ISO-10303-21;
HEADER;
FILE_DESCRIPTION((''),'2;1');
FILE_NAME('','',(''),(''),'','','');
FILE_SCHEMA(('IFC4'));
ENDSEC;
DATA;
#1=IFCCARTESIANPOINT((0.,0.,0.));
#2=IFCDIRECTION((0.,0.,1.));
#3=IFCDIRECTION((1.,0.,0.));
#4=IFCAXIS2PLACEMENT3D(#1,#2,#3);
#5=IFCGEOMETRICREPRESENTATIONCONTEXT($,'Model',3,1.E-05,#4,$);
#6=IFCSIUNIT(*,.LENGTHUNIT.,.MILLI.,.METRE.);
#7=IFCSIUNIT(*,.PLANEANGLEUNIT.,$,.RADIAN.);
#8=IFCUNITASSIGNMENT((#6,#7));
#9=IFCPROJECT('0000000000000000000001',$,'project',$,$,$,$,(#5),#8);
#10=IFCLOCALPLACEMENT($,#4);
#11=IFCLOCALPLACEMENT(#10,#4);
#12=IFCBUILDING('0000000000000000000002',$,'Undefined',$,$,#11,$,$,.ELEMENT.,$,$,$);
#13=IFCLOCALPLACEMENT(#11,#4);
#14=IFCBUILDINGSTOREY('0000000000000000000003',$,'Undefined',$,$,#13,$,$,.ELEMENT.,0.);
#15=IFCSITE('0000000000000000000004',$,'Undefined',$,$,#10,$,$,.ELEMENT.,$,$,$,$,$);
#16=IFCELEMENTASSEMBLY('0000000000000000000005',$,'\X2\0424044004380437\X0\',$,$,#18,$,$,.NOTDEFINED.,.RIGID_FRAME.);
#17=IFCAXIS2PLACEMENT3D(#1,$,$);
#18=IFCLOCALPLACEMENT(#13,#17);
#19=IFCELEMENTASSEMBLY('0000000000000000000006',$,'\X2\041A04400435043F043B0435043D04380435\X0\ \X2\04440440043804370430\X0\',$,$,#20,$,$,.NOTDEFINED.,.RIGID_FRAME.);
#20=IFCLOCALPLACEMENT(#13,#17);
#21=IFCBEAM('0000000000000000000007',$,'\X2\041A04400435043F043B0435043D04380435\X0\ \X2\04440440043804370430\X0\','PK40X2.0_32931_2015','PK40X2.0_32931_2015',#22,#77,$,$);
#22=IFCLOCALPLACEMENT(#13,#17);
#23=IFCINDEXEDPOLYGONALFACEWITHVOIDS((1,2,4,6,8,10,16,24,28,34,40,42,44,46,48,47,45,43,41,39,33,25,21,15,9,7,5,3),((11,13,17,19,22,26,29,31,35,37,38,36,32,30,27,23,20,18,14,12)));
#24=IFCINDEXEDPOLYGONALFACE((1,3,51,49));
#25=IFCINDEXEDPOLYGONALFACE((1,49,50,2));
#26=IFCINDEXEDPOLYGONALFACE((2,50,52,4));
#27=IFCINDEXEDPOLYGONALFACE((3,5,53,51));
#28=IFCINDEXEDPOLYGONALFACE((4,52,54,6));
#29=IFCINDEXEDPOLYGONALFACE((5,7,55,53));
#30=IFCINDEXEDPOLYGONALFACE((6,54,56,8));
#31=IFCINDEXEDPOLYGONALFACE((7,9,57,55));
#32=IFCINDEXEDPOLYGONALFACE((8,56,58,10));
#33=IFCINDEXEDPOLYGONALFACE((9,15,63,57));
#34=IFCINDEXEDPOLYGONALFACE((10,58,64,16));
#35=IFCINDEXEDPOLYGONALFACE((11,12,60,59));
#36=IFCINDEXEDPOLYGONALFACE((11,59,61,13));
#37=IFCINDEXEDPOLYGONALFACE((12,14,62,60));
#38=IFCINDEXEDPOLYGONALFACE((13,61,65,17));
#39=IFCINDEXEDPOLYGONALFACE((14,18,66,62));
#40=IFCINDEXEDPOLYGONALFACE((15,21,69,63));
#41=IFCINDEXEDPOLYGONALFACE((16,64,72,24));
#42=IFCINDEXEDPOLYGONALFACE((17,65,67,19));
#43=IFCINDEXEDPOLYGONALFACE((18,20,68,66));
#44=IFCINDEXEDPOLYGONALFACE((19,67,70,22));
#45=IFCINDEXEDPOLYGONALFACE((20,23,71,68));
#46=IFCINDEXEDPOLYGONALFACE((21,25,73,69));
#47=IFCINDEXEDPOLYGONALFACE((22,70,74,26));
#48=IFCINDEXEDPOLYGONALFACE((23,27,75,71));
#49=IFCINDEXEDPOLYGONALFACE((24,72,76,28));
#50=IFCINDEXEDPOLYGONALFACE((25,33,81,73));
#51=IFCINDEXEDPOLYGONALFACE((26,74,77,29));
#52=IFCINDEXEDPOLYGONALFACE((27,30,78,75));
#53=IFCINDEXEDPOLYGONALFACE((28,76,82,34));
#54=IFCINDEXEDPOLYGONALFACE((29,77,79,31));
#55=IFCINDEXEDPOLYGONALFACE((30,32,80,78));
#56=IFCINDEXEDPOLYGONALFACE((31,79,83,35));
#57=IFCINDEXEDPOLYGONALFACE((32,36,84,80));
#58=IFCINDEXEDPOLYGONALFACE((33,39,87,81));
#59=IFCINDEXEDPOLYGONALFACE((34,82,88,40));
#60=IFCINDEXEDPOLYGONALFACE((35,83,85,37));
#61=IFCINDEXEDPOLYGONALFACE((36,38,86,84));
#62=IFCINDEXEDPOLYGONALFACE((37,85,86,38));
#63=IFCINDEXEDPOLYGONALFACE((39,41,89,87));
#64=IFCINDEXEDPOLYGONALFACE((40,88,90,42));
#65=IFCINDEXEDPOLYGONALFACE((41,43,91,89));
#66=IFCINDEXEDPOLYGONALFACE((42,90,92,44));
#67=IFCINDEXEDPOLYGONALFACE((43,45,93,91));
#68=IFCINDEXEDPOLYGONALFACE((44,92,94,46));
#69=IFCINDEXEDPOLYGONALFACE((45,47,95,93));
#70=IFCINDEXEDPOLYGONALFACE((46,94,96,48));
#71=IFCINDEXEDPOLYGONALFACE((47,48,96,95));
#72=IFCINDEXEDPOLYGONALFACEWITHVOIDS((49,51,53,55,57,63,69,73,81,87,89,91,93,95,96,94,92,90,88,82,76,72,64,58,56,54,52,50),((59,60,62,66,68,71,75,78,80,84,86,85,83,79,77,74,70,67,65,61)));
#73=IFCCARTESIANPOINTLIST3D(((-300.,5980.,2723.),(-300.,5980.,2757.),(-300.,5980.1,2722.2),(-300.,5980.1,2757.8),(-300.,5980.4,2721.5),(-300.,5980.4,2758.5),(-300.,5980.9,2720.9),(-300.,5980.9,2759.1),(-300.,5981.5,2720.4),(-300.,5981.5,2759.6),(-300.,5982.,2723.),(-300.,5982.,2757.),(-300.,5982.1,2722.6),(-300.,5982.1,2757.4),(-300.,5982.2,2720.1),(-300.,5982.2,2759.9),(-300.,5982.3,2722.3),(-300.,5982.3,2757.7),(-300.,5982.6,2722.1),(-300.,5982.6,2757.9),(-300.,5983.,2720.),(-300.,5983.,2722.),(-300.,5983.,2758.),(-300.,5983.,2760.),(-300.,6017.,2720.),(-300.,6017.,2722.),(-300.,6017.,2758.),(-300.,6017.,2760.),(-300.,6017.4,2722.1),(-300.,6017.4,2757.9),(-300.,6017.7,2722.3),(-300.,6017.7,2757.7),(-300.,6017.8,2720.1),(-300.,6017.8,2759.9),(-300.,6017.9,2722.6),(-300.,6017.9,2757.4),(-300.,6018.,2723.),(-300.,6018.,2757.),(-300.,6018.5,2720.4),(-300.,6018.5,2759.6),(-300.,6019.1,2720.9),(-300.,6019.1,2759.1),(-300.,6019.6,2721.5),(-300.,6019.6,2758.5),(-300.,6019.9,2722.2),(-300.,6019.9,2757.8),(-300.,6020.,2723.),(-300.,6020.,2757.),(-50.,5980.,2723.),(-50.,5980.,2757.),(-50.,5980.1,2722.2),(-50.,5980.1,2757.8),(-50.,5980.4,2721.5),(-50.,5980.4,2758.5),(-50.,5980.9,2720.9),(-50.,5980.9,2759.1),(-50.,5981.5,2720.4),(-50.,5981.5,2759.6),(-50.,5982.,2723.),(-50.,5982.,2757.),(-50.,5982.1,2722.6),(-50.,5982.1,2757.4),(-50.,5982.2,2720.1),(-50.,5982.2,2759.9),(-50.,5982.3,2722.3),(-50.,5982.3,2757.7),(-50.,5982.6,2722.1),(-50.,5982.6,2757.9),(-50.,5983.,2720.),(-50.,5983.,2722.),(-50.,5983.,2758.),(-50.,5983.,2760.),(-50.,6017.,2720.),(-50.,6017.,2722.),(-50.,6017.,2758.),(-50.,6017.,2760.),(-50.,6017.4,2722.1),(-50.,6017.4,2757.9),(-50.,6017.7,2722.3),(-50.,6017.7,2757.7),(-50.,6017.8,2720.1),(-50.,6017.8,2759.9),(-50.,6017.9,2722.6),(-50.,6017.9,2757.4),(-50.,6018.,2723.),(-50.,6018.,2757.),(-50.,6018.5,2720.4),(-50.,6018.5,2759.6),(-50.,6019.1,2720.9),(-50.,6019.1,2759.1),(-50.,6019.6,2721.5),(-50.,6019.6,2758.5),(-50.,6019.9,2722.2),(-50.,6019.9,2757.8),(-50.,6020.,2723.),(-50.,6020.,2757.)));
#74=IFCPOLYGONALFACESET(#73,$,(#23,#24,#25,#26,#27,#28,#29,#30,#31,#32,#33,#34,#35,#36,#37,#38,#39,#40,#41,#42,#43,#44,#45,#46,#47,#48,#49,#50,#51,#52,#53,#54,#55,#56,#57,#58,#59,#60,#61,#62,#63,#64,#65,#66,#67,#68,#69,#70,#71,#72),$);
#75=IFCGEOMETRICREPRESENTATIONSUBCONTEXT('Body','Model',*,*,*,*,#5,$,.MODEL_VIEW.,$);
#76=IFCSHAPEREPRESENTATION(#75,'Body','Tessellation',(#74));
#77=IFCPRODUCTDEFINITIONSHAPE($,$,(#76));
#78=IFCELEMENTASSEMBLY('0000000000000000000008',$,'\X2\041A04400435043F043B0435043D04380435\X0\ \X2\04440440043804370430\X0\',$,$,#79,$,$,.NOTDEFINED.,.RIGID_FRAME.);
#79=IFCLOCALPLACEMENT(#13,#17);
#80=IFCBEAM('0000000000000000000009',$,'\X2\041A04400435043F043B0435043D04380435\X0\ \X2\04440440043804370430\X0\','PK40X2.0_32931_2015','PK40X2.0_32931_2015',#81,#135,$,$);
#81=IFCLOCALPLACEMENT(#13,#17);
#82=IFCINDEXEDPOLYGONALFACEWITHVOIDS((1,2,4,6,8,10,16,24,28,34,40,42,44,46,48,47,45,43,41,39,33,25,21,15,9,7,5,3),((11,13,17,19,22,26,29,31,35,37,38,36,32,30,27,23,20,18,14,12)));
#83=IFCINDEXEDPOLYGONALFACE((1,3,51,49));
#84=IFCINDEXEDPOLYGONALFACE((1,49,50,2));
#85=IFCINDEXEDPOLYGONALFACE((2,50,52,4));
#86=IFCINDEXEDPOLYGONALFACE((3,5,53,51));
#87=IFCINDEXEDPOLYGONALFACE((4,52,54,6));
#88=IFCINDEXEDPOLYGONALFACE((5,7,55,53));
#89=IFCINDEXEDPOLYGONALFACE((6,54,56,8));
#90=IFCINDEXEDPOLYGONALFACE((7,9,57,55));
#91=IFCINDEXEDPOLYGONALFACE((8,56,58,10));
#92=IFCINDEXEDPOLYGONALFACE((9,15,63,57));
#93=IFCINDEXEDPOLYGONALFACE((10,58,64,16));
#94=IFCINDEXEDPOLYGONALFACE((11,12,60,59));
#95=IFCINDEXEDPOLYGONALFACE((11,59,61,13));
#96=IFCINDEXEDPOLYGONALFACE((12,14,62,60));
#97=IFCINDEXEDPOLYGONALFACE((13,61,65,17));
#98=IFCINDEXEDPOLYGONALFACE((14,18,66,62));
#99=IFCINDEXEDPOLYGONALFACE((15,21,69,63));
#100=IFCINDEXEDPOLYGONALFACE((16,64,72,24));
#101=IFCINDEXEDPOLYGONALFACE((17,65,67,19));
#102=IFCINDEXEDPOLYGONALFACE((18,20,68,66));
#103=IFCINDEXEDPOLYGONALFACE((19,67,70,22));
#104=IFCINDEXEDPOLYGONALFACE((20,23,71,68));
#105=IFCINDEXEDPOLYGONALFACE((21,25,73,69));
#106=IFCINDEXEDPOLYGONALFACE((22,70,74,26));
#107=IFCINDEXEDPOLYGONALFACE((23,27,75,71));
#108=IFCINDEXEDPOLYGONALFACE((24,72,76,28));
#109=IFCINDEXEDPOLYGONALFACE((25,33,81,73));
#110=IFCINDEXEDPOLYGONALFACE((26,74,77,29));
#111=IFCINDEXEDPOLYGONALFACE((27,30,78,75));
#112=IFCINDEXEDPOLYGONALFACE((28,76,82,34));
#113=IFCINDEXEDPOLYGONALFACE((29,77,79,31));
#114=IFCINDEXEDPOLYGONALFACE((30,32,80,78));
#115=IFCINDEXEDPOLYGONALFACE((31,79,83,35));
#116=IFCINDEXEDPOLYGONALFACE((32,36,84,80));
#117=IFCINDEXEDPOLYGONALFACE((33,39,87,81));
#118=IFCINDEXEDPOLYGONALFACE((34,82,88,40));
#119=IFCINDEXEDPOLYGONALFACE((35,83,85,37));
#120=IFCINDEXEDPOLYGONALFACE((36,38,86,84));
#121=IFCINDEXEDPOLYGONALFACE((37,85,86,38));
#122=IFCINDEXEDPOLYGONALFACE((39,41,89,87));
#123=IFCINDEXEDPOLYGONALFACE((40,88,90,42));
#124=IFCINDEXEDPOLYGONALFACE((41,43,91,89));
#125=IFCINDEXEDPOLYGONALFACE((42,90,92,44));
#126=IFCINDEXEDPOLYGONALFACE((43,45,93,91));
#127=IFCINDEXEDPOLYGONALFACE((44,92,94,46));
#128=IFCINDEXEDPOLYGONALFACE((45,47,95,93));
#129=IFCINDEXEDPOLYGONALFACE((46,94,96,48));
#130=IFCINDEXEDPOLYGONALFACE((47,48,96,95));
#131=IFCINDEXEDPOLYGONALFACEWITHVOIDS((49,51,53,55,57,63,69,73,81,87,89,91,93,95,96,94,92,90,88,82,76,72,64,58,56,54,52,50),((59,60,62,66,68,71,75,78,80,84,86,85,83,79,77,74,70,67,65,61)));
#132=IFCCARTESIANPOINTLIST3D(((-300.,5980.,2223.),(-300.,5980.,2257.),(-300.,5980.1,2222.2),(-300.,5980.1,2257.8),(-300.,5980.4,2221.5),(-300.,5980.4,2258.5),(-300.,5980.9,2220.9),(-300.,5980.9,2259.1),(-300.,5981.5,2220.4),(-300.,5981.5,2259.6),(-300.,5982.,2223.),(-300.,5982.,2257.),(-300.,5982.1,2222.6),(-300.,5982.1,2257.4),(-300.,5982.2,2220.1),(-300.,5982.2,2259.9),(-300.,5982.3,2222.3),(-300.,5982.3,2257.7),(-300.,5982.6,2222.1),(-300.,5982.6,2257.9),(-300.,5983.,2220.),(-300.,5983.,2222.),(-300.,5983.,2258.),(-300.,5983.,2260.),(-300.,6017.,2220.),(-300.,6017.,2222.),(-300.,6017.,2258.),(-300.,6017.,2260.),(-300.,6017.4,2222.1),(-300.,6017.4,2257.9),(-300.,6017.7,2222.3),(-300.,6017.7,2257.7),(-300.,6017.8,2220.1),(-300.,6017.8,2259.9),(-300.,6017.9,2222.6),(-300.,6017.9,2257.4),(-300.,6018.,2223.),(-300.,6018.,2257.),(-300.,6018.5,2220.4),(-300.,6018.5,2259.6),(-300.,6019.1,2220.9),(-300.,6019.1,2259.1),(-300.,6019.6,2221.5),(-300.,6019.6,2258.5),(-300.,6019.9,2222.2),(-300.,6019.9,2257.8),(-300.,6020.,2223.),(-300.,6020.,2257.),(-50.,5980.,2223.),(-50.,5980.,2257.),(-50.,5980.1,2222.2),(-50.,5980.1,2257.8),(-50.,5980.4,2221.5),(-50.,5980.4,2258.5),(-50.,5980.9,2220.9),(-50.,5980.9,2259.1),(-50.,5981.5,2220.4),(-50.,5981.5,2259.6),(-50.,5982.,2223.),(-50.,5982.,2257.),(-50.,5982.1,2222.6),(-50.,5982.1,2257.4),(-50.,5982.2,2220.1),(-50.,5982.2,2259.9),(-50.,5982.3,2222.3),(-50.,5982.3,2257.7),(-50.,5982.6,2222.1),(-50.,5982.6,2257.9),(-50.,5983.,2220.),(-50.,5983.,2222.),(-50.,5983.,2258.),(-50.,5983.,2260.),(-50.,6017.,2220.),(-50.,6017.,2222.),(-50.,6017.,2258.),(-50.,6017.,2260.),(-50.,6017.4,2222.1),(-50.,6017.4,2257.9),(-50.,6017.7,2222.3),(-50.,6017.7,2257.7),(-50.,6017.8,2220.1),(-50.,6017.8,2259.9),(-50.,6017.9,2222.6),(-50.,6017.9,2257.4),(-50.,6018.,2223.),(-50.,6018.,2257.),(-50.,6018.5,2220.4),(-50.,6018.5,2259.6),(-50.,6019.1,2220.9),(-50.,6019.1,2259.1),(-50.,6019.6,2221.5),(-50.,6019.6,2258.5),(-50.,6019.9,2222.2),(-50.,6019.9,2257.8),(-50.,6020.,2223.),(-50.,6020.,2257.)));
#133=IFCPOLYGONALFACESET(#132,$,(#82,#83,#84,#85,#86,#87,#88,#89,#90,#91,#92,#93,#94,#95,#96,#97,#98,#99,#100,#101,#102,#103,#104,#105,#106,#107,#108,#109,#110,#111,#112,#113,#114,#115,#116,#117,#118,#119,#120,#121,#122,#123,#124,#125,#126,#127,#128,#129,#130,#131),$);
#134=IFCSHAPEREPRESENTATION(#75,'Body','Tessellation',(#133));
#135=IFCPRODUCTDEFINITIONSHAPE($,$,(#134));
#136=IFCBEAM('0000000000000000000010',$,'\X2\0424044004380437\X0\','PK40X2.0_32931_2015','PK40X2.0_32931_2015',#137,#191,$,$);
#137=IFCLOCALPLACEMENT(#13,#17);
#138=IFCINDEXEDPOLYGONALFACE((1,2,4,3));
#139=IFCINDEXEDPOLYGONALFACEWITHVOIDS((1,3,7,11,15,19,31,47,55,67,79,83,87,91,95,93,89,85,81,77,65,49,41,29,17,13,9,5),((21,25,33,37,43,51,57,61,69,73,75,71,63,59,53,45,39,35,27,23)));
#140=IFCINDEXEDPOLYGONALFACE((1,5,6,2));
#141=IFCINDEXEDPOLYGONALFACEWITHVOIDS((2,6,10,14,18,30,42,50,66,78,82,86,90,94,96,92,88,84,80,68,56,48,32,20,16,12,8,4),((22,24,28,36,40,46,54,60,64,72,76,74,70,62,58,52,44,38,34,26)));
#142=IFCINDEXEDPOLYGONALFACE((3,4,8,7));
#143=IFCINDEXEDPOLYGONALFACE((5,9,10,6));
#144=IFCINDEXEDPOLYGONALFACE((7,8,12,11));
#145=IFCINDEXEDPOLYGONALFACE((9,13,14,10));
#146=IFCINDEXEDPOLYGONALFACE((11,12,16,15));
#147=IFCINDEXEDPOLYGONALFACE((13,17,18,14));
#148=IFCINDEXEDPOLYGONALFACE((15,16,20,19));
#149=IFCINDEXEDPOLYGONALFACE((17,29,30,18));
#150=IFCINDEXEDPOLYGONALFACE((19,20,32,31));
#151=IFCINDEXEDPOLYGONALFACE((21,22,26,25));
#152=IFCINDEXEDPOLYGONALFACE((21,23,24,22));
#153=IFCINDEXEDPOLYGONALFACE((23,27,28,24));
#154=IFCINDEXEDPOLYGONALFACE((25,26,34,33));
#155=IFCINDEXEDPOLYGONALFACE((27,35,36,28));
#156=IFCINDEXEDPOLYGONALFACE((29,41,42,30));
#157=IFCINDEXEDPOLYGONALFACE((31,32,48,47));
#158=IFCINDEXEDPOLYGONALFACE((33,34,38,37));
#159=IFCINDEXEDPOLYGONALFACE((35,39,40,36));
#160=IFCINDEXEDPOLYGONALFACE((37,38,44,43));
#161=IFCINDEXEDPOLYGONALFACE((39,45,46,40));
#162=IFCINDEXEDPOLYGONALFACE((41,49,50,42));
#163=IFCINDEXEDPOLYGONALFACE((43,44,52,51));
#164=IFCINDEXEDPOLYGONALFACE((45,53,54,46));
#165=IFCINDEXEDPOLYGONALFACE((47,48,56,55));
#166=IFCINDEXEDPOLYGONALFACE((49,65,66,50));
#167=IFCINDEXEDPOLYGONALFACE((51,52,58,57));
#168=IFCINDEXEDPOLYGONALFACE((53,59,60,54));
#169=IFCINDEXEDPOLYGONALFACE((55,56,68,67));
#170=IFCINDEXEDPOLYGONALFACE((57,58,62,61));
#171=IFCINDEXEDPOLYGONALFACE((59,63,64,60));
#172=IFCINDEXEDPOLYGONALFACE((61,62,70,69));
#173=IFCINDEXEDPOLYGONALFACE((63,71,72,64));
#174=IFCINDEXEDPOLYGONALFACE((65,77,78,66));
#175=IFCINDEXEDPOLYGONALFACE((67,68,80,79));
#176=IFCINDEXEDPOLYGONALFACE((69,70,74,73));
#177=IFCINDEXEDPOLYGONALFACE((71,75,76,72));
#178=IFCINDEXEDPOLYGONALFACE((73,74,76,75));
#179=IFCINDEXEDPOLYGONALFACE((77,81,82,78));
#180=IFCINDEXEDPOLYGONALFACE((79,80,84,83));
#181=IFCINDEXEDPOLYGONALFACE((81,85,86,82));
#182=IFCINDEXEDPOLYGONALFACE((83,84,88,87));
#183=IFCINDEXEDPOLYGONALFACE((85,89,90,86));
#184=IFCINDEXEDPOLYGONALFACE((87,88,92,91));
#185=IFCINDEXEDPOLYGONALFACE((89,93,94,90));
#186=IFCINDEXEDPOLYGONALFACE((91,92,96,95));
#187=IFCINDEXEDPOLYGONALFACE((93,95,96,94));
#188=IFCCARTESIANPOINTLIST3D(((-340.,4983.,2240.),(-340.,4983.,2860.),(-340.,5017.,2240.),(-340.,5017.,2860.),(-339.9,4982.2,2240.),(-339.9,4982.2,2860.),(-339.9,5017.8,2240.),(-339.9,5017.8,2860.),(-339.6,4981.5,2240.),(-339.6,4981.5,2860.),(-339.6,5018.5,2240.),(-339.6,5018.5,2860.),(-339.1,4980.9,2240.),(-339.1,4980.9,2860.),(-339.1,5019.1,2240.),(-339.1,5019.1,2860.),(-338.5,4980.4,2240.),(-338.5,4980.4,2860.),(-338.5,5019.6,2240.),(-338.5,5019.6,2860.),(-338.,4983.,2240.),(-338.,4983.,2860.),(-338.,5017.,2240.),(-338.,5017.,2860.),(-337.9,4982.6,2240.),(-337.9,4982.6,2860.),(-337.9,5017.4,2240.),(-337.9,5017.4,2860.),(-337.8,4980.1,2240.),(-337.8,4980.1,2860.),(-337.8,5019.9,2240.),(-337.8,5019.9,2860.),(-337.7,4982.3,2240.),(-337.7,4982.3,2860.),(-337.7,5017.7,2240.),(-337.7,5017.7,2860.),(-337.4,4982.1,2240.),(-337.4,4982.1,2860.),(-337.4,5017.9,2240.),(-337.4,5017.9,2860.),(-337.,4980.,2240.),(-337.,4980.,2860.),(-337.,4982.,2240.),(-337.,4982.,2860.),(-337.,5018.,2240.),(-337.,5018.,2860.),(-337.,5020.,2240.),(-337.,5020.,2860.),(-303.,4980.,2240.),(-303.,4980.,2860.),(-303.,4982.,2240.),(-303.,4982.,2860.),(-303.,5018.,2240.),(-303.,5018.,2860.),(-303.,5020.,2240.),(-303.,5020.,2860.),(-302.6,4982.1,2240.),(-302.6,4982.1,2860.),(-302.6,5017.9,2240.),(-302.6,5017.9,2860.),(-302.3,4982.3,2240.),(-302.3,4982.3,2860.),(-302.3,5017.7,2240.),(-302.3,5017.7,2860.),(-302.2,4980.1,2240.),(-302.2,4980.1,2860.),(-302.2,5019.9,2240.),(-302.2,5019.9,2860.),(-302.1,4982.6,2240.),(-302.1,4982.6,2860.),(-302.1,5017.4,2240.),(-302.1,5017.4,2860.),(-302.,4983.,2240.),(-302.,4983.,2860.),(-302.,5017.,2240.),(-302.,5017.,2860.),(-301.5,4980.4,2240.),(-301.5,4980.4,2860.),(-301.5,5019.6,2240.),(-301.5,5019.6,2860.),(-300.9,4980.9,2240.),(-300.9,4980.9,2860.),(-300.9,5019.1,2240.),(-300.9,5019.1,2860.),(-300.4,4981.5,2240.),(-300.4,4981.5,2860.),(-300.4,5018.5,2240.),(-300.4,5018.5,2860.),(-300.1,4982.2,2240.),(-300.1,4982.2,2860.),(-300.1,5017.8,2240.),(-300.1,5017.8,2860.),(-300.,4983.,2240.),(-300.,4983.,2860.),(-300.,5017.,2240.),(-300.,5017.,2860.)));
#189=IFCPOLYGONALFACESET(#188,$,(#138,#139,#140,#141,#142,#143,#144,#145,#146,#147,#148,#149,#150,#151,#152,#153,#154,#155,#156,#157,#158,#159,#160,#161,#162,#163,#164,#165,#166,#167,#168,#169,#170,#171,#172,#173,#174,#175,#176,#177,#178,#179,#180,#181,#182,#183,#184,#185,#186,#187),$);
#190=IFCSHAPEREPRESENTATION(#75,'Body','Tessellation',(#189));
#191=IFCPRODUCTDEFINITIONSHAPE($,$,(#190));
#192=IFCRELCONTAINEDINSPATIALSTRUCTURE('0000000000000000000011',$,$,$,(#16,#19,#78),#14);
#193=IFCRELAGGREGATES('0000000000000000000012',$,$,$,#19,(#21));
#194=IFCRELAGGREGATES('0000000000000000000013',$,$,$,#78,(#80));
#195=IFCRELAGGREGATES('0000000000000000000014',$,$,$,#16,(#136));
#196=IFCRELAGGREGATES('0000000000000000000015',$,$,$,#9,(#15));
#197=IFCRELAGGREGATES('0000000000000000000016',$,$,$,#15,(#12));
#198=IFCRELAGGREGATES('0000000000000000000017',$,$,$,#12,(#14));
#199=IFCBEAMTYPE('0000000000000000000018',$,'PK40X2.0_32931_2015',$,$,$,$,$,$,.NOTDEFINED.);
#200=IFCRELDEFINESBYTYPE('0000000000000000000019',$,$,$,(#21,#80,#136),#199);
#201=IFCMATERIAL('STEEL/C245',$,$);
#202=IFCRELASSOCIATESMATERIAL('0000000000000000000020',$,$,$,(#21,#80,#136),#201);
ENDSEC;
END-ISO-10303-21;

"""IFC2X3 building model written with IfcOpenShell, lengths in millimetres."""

from ifc_helpers import new_model, si_unit, frame, origin_with_axes, origin_2d_with_axis, place, context, subcontext, project, spatial, hollow_rectangle, extrude, material, type_object, element, aggregate, save


model = new_model("IFC2X3")

# Units and contexts
model_context = context("Model", 3, precision=1e-05, world=origin_with_axes())
body_context = subcontext(model_context, "Body", "Model", "MODEL_VIEW")
ifc_project = project(units=[si_unit("LENGTHUNIT", "METRE", prefix="MILLI"), si_unit("PLANEANGLEUNIT", "RADIAN")], contexts=[model_context])

# Site, building, storey
site_placement = place(None, origin_with_axes())
site = spatial("IfcSite", under=ifc_project, at=site_placement, Name="Undefined", CompositionType="ELEMENT")
building_placement = place(site_placement, origin_with_axes())
building = spatial("IfcBuilding", under=site, at=building_placement, Name="Undefined", CompositionType="ELEMENT")
storey_placement = place(building_placement, origin_with_axes())
storey = spatial("IfcBuildingStorey", under=building, at=storey_placement, Name="Undefined", CompositionType="ELEMENT", Elevation=0.0)

# Shared definitions
ifc_material_1 = material(Name="STEEL/C245")

# Element assembly
assembly_1_placement = place(storey_placement, origin_with_axes())
assembly_1 = element("IfcElementAssembly", 1, at=assembly_1_placement, inside=storey, Name="Фриз", AssemblyPlace="NOTDEFINED", PredefinedType="RIGID_FRAME")

# Element assemblies, beams
assembly_2_placement = place(storey_placement, origin_with_axes())
assembly_2 = element("IfcElementAssembly", 2, at=assembly_2_placement, inside=storey, Name="Крепление фриза", AssemblyPlace="NOTDEFINED", PredefinedType="RIGID_FRAME")
beam_type_1 = type_object("IfcBeamType", Name="PK40X2.0_32931_2015", PredefinedType="NOTDEFINED")
beam_1_placement = place(assembly_2_placement, frame((-300.0, 6000.0, 2740.0), z_axis=(0.0, 0.0, -1.0), x_axis=(1.0, 0.0, 0.0)))
beam_1 = element("IfcBeam", 3, at=beam_1_placement, type_object=beam_type_1, material=ifc_material_1, Name="Крепление фриза", Description="PK40X2.0_32931_2015", ObjectType="PK40X2.0_32931_2015", context=body_context, shape_type="SweptSolid", body=[
    extrude(hollow_rectangle(XDim=40.0, YDim=40.0, WallThickness=2.0, InnerFilletRadius=1.0, OuterFilletRadius=3.0, at=origin_2d_with_axis()), frame((250.0, 0.0, 0.0), z_axis=(-1.0, 0.0, 0.0), x_axis=(0.0, -1.0, 0.0)), (0.0, 0.0, 1.0), 250.0),
])
aggregate(assembly_2, [beam_1])
assembly_3_placement = place(storey_placement, origin_with_axes())
assembly_3 = element("IfcElementAssembly", 4, at=assembly_3_placement, inside=storey, Name="Крепление фриза", AssemblyPlace="NOTDEFINED", PredefinedType="RIGID_FRAME")
beam_2_placement = place(assembly_3_placement, frame((-300.0, 6000.0, 2240.0), z_axis=(0.0, 0.0, -1.0), x_axis=(1.0, 0.0, 0.0)))
beam_2 = element("IfcBeam", 5, at=beam_2_placement, type_object=beam_type_1, material=ifc_material_1, Name="Крепление фриза", Description="PK40X2.0_32931_2015", ObjectType="PK40X2.0_32931_2015", context=body_context, shape_type="SweptSolid", body=[
    extrude(hollow_rectangle(XDim=40.0, YDim=40.0, WallThickness=2.0, InnerFilletRadius=1.0, OuterFilletRadius=3.0, at=origin_2d_with_axis()), frame((250.0, 0.0, 0.0), z_axis=(-1.0, 0.0, 0.0), x_axis=(0.0, -1.0, 0.0)), (0.0, 0.0, 1.0), 250.0),
])
aggregate(assembly_3, [beam_2])

# Beam
beam_3_placement = place(assembly_1_placement, frame((-320.0, 5000.0, 2860.0), z_axis=(1.0, 0.0, 0.0), x_axis=(0.0, 0.0, -1.0)))
beam_3 = element("IfcBeam", 6, at=beam_3_placement, type_object=beam_type_1, material=ifc_material_1, Name="Фриз", Description="PK40X2.0_32931_2015", ObjectType="PK40X2.0_32931_2015", context=body_context, shape_type="SweptSolid", body=[
    extrude(hollow_rectangle(XDim=40.0, YDim=40.0, WallThickness=2.0, InnerFilletRadius=1.0, OuterFilletRadius=3.0, at=origin_2d_with_axis()), frame((620.0, 0.0, 0.0), z_axis=(-1.0, 0.0, 0.0), x_axis=(0.0, -1.0, 0.0)), (0.0, 0.0, 1.0), 620.0),
])
aggregate(assembly_1, [beam_3])

save(model, "model.ifc")
